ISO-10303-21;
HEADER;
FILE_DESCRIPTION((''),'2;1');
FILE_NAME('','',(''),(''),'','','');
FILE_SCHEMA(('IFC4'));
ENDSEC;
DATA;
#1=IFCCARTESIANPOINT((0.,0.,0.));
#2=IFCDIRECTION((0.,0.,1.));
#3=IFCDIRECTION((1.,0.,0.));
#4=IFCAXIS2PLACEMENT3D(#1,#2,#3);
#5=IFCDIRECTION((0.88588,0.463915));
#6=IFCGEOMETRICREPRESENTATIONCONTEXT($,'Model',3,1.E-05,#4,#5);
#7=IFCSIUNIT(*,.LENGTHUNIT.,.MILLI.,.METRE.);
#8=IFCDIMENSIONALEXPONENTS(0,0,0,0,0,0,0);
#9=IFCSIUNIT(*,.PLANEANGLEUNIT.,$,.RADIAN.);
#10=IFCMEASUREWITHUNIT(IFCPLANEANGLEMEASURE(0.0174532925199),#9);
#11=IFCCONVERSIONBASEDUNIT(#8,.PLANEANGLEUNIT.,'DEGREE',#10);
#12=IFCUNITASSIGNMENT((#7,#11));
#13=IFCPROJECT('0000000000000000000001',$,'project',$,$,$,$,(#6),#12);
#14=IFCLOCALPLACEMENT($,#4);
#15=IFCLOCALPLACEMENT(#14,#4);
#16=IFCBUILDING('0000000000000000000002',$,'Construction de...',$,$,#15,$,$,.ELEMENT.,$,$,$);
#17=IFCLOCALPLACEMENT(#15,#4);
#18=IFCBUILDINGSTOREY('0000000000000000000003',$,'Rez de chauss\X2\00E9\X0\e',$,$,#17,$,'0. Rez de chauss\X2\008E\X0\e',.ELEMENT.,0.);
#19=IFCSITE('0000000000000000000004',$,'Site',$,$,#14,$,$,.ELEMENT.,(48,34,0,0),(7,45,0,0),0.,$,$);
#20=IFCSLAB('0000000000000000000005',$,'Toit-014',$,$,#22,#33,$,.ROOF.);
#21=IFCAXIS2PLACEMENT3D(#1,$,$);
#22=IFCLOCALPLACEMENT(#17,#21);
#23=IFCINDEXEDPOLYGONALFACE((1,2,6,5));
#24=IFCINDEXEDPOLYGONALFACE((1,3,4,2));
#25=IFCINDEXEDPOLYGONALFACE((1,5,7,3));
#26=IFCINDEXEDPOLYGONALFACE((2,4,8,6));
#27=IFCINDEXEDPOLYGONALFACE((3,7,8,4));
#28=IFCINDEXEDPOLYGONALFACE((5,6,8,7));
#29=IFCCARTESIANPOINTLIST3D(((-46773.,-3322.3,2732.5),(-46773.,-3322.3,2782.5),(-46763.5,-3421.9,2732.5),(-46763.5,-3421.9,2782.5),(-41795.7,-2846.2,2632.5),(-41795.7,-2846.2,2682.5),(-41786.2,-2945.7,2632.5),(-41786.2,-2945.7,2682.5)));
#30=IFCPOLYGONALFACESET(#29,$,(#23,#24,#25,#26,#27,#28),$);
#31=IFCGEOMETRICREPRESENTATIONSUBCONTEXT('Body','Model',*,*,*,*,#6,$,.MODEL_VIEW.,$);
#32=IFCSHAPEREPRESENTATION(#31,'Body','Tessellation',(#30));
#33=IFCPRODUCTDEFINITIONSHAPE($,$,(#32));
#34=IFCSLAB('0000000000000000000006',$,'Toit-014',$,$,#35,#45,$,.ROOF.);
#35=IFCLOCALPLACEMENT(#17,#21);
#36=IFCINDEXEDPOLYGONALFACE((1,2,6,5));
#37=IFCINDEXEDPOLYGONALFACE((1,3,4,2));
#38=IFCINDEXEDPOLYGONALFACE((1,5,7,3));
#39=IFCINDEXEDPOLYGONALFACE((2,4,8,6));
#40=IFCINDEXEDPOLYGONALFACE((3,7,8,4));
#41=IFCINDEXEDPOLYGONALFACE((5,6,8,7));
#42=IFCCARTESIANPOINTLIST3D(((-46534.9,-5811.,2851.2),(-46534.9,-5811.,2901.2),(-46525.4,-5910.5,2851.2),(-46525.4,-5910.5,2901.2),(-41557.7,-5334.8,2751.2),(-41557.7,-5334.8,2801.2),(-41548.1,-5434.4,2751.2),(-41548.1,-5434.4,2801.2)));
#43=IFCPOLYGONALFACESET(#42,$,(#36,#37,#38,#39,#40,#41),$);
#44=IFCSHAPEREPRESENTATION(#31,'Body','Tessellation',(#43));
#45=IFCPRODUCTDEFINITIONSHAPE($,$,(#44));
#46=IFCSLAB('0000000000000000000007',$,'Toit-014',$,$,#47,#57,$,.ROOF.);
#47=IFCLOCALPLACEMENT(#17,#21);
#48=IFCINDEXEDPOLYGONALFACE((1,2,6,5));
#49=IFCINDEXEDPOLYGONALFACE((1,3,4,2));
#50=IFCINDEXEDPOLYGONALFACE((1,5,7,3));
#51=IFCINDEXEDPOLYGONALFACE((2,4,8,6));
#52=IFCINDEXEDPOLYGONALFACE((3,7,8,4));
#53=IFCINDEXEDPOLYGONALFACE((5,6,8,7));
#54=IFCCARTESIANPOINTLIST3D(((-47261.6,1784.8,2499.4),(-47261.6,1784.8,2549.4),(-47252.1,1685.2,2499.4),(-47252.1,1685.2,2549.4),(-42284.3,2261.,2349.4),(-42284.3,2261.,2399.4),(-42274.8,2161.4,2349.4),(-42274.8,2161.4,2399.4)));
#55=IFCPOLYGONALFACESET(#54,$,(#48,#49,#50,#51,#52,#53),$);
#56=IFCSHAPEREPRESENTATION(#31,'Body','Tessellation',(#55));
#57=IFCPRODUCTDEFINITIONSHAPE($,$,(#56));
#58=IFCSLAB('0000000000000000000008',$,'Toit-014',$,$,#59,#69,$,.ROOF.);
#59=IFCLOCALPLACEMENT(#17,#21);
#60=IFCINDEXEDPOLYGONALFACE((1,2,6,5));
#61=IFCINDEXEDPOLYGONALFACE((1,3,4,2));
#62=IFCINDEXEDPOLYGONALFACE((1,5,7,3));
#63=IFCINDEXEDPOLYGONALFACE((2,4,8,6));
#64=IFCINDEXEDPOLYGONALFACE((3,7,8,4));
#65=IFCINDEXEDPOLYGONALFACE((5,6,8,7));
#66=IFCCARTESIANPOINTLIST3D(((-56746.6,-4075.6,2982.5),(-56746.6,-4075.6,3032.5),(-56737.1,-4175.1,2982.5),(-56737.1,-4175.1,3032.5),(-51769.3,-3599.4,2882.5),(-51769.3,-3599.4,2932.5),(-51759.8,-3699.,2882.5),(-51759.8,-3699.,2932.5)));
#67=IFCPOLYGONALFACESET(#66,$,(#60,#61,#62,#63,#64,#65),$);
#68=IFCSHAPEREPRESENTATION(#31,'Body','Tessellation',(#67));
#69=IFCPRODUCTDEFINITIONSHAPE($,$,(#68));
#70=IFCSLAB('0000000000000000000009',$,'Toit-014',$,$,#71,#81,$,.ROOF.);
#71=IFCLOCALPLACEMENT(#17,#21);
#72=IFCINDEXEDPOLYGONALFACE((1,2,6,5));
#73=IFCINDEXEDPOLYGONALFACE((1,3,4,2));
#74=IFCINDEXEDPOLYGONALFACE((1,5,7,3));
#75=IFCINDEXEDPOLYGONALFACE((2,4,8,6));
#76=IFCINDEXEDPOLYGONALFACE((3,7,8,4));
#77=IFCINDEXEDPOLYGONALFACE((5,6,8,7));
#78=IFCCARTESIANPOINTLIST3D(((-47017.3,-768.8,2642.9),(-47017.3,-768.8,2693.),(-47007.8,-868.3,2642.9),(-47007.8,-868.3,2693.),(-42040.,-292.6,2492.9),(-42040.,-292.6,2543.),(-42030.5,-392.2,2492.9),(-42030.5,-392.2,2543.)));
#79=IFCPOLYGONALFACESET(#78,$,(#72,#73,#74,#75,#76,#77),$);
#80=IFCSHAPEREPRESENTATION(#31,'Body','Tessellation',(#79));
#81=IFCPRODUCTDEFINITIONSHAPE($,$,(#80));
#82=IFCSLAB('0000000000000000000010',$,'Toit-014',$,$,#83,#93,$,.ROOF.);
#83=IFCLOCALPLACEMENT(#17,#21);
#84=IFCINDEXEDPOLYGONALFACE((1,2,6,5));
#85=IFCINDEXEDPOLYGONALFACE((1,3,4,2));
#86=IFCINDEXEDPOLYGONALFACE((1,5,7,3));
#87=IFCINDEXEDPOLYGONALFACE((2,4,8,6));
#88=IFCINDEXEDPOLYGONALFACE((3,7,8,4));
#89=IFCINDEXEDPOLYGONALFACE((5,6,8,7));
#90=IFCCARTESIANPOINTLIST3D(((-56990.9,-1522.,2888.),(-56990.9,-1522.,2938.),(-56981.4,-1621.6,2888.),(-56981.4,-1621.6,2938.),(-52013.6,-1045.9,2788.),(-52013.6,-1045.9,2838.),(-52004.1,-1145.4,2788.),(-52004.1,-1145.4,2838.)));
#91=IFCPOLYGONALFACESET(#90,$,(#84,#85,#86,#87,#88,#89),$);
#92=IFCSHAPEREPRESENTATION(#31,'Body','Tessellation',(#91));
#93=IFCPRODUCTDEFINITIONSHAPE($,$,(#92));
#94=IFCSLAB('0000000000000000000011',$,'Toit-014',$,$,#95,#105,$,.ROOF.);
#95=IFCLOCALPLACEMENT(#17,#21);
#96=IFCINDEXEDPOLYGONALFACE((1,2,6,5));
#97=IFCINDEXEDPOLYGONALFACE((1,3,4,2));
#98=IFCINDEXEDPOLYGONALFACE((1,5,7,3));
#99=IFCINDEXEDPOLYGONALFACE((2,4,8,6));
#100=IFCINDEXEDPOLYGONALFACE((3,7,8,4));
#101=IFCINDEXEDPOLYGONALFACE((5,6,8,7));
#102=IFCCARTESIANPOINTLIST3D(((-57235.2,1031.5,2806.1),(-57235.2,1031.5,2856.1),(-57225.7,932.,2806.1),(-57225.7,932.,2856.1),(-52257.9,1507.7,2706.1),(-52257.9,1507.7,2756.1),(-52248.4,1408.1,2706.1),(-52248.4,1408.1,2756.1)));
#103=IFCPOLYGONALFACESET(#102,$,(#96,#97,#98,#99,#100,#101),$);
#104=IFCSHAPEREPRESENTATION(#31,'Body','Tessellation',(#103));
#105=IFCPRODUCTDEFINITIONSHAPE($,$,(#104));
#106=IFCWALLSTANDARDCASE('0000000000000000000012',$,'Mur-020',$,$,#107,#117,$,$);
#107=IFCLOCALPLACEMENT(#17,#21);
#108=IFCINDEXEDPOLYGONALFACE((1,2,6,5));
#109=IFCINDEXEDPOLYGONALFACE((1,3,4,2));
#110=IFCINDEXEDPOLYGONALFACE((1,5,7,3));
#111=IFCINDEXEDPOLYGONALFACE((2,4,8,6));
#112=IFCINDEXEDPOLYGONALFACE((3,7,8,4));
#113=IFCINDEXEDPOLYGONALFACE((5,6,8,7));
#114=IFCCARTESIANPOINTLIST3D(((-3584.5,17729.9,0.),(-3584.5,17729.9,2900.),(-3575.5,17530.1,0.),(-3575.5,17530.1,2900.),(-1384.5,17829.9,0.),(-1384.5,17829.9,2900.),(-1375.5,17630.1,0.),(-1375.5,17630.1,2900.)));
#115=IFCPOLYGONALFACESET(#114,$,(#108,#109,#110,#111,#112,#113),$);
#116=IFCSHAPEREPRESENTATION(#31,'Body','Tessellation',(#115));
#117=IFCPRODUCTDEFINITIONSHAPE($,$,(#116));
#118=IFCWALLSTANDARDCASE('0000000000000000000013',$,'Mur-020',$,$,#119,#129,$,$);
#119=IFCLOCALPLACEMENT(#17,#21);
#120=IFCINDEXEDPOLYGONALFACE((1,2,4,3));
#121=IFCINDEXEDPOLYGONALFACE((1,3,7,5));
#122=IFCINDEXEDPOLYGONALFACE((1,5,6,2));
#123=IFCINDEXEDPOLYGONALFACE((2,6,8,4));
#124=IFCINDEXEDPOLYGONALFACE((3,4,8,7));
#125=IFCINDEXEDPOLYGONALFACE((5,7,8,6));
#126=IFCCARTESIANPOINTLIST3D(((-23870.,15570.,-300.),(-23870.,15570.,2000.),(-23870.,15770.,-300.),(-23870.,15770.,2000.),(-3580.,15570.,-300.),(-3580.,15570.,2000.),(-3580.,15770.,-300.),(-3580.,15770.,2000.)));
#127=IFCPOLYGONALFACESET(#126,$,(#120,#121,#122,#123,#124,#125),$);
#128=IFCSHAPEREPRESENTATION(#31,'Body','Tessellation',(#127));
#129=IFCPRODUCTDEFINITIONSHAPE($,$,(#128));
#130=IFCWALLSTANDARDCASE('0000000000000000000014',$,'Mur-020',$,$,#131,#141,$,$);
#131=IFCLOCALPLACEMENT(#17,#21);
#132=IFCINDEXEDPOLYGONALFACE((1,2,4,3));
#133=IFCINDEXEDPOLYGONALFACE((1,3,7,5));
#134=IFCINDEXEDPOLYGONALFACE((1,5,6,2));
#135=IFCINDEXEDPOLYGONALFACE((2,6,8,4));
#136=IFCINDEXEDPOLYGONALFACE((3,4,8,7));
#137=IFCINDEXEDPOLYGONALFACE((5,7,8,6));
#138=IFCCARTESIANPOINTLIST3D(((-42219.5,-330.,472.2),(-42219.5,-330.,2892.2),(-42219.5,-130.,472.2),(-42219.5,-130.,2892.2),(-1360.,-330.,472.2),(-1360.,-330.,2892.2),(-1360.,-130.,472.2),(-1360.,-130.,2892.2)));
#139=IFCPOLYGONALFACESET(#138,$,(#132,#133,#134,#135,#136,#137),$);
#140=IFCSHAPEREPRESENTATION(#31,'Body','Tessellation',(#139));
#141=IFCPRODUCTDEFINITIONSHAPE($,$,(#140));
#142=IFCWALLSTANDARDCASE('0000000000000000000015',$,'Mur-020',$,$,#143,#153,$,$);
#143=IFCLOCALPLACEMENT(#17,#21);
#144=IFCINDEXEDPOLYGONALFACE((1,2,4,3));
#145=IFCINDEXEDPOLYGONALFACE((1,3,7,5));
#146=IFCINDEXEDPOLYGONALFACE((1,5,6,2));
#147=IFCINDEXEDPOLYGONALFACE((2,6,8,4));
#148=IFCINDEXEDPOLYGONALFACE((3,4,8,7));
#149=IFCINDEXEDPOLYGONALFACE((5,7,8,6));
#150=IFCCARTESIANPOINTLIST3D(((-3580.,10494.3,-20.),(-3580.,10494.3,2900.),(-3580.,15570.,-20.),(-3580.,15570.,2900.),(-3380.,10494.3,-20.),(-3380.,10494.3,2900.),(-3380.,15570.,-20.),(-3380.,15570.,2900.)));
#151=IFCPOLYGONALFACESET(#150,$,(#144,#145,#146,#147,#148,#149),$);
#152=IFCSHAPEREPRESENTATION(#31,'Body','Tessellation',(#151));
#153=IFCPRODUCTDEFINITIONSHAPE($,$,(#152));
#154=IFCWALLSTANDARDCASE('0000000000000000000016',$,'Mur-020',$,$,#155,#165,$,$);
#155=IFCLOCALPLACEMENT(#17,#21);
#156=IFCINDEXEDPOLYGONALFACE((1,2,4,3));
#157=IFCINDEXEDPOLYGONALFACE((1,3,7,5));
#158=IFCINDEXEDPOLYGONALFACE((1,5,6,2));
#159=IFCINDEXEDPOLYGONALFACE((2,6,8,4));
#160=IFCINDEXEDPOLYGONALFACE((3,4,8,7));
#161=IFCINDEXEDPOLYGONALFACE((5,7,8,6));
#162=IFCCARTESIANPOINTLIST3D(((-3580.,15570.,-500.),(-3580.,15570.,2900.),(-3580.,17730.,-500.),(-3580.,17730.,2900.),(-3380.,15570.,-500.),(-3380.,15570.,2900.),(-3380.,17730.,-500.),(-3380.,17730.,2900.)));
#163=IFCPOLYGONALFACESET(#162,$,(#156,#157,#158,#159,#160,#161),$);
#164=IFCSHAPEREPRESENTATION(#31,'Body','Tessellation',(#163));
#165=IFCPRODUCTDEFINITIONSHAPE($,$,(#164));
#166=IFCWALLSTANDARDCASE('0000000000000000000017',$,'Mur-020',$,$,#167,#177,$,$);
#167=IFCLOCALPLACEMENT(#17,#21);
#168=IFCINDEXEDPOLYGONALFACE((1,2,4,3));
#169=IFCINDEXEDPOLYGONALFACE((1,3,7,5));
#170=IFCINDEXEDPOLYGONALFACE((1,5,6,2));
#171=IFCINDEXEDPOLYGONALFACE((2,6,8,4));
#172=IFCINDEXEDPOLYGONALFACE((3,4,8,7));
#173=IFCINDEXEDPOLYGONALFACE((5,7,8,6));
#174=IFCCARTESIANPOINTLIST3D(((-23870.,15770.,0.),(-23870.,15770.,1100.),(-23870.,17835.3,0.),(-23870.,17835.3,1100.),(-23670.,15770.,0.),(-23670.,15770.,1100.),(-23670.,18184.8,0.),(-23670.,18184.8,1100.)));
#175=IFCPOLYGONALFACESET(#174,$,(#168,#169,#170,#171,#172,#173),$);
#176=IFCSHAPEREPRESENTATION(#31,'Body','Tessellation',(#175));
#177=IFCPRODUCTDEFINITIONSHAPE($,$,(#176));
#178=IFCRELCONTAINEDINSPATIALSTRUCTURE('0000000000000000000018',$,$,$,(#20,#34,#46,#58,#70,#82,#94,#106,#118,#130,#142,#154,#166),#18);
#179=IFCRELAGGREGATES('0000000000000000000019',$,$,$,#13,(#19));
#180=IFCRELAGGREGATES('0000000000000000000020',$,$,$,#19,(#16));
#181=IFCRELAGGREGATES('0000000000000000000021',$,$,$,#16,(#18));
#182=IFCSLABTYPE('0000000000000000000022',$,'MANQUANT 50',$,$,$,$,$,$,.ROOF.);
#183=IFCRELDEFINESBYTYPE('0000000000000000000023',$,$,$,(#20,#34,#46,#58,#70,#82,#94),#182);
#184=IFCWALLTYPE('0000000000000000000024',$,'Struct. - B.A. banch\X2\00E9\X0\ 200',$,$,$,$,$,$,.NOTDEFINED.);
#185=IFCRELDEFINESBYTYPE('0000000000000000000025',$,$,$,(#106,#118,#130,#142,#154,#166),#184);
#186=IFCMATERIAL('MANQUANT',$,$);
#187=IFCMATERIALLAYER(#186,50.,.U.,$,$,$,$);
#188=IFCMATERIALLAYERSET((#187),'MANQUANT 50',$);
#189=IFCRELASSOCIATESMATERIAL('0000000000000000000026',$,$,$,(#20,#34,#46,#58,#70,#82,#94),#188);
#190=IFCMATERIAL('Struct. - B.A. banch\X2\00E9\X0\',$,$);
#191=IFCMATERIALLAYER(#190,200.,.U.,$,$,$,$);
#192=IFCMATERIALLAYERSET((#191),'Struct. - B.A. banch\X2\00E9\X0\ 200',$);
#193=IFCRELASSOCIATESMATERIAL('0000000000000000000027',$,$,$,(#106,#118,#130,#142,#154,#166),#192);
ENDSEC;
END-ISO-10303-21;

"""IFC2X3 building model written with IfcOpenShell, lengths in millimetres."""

from ifc_helpers import new_model, entity, si_unit, converted_unit, direction, frame, origin_with_axes, place, context, subcontext, project, spatial, polyline, outline, extrude, material, layer, layer_set, layer_usage, type_object, element, save


model = new_model("IFC2X3")

# Units and contexts
model_context = context("Model", 3, precision=1e-05, world=origin_with_axes(), true_north=direction((0.88588, 0.463915)))
body_context = subcontext(model_context, "Body", "Model", "MODEL_VIEW")
ifc_project = project(units=[si_unit("LENGTHUNIT", "METRE", prefix="MILLI"), converted_unit("PLANEANGLEUNIT", "DEGREE", entity("IfcPlaneAngleMeasure", 0.0174532925199), si_unit("PLANEANGLEUNIT", "RADIAN"), dimensions=[0, 0, 0, 0, 0, 0, 0])], contexts=[model_context])

# Site, building, storey
site_placement = place(None, origin_with_axes())
site = spatial("IfcSite", under=ifc_project, at=site_placement, Name="Site", CompositionType="ELEMENT", RefLatitude=(48, 34, 0, 0), RefLongitude=(7, 45, 0, 0), RefElevation=0.0)
building_placement = place(site_placement, origin_with_axes())
building = spatial("IfcBuilding", under=site, at=building_placement, Name="Construction de...", CompositionType="ELEMENT")
storey_placement = place(building_placement, origin_with_axes())
storey = spatial("IfcBuildingStorey", under=building, at=storey_placement, Name="Rez de chaussée", LongName="0. Rez de chauss\u008ee", CompositionType="ELEMENT", Elevation=0.0)

# Slabs
ifc_material_1 = material(Name="MANQUANT")
ifc_layer_1 = layer(ifc_material_1, 50.0, ventilated="UNKNOWN")
ifc_layer_set_1 = layer_set([ifc_layer_1], Name="MANQUANT 50")
ifc_layer_usage_1 = layer_usage(ifc_layer_set_1, "AXIS3", "NEGATIVE", 50.0)
slab_type_1 = type_object("IfcSlabType", Name="MANQUANT 50", PredefinedType="ROOF")
slab_1_placement = place(storey_placement, frame((-41786.2, -2945.7, 2632.5), z_axis=(0.0, 0.0, 1.0), x_axis=(-0.095235, 0.995455, 0.0)))
element("IfcSlab", 1, at=slab_1_placement, inside=storey, type_object=slab_type_1, material=ifc_layer_usage_1, Name="Toit-014", PredefinedType="ROOF", context=body_context, shape_type="SweptSolid", body=[
    extrude(outline(polyline([(0.0, 0.0), (100.0, 0.0), (100.0, 5001.0), (0.0, 5001.0), (0.0, 0.0)])), frame((0.0, 0.0, 0.0), z_axis=(0.0, -0.019996, 0.9998), x_axis=(1.0, 0.0, 0.0)), (0.0, 0.019996, 0.9998), 50.0),
])
ifc_layer_usage_2 = layer_usage(ifc_layer_set_1, "AXIS3", "NEGATIVE", 50.0)
slab_2_placement = place(storey_placement, frame((-41548.1, -5434.4, 2751.2), z_axis=(0.0, 0.0, 1.0), x_axis=(-0.095235, 0.995455, 0.0)))
element("IfcSlab", 2, at=slab_2_placement, inside=storey, type_object=slab_type_1, material=ifc_layer_usage_2, Name="Toit-014", PredefinedType="ROOF", context=body_context, shape_type="SweptSolid", body=[
    extrude(outline(polyline([(0.0, 0.0), (100.0, 0.0), (100.0, 5001.0), (0.0, 5001.0), (0.0, 0.0)])), frame((0.0, 0.0, 0.0), z_axis=(0.0, -0.019996, 0.9998), x_axis=(1.0, 0.0, 0.0)), (0.0, 0.019996, 0.9998), 50.0),
])
ifc_layer_usage_3 = layer_usage(ifc_layer_set_1, "AXIS3", "NEGATIVE", 50.0)
slab_3_placement = place(storey_placement, frame((-42274.8, 2161.4, 2349.4), z_axis=(0.0, 0.0, 1.0), x_axis=(-0.095235, 0.995455, 0.0)))
element("IfcSlab", 3, at=slab_3_placement, inside=storey, type_object=slab_type_1, material=ifc_layer_usage_3, Name="Toit-014", PredefinedType="ROOF", context=body_context, shape_type="SweptSolid", body=[
    extrude(outline(polyline([(0.0, 0.0), (100.0, 0.0), (100.0, 5002.2), (0.0, 5002.2), (0.0, 0.0)])), frame((0.0, 0.0, 0.0), z_axis=(0.0, -0.029987, 0.99955), x_axis=(1.0, 0.0, 0.0)), (0.0, 0.029987, 0.99955), 50.0),
])
ifc_layer_usage_4 = layer_usage(ifc_layer_set_1, "AXIS3", "NEGATIVE", 50.0)
slab_4_placement = place(storey_placement, frame((-51759.8, -3699.0, 2882.5), z_axis=(0.0, 0.0, 1.0), x_axis=(-0.095235, 0.995455, 0.0)))
element("IfcSlab", 4, at=slab_4_placement, inside=storey, type_object=slab_type_1, material=ifc_layer_usage_4, Name="Toit-014", PredefinedType="ROOF", context=body_context, shape_type="SweptSolid", body=[
    extrude(outline(polyline([(0.0, 0.0), (100.0, 0.0), (100.0, 5001.0), (0.0, 5001.0), (0.0, 0.0)])), frame((0.0, 0.0, 0.0), z_axis=(0.0, -0.019996, 0.9998), x_axis=(1.0, 0.0, 0.0)), (0.0, 0.019996, 0.9998), 50.0),
])
ifc_layer_usage_5 = layer_usage(ifc_layer_set_1, "AXIS3", "NEGATIVE", 50.0)
slab_5_placement = place(storey_placement, frame((-42030.5, -392.2, 2492.9), z_axis=(0.0, 0.0, 1.0), x_axis=(-0.095235, 0.995455, 0.0)))
element("IfcSlab", 5, at=slab_5_placement, inside=storey, type_object=slab_type_1, material=ifc_layer_usage_5, Name="Toit-014", PredefinedType="ROOF", context=body_context, shape_type="SweptSolid", body=[
    extrude(outline(polyline([(0.0, 0.0), (100.0, 0.0), (100.0, 5002.2), (0.0, 5002.2), (0.0, 0.0)])), frame((0.0, 0.0, 0.0), z_axis=(0.0, -0.029987, 0.99955), x_axis=(1.0, 0.0, 0.0)), (0.0, 0.029987, 0.99955), 50.0),
])
ifc_layer_usage_6 = layer_usage(ifc_layer_set_1, "AXIS3", "NEGATIVE", 50.0)
slab_6_placement = place(storey_placement, frame((-52004.1, -1145.4, 2788.0), z_axis=(0.0, 0.0, 1.0), x_axis=(-0.095235, 0.995455, 0.0)))
element("IfcSlab", 6, at=slab_6_placement, inside=storey, type_object=slab_type_1, material=ifc_layer_usage_6, Name="Toit-014", PredefinedType="ROOF", context=body_context, shape_type="SweptSolid", body=[
    extrude(outline(polyline([(0.0, 0.0), (100.0, 0.0), (100.0, 5001.0), (0.0, 5001.0), (0.0, 0.0)])), frame((0.0, 0.0, 0.0), z_axis=(0.0, -0.019996, 0.9998), x_axis=(1.0, 0.0, 0.0)), (0.0, 0.019996, 0.9998), 50.0),
])
ifc_layer_usage_7 = layer_usage(ifc_layer_set_1, "AXIS3", "NEGATIVE", 50.0)
slab_7_placement = place(storey_placement, frame((-52248.4, 1408.1, 2706.1), z_axis=(0.0, 0.0, 1.0), x_axis=(-0.095235, 0.995455, 0.0)))
element("IfcSlab", 7, at=slab_7_placement, inside=storey, type_object=slab_type_1, material=ifc_layer_usage_7, Name="Toit-014", PredefinedType="ROOF", context=body_context, shape_type="SweptSolid", body=[
    extrude(outline(polyline([(0.0, 0.0), (100.0, 0.0), (100.0, 5001.0), (0.0, 5001.0), (0.0, 0.0)])), frame((0.0, 0.0, 0.0), z_axis=(0.0, -0.019996, 0.9998), x_axis=(1.0, 0.0, 0.0)), (0.0, 0.019996, 0.9998), 50.0),
])

# Walls
ifc_material_2 = material(Name="Struct. - B.A. banché")
ifc_layer_2 = layer(ifc_material_2, 200.0, ventilated="UNKNOWN")
ifc_layer_set_2 = layer_set([ifc_layer_2], Name="Struct. - B.A. banché 200")
ifc_layer_usage_8 = layer_usage(ifc_layer_set_2, "AXIS2", "NEGATIVE", 100.0)
wall_type_1 = type_object("IfcWallType", Name="Struct. - B.A. banché 200", PredefinedType="NOTDEFINED")
wall_1_placement = place(storey_placement, frame((-3580.0, 17630.0, 0.0), z_axis=(0.0, 0.0, 1.0), x_axis=(0.998969, 0.045408, 0.0)))
element("IfcWallStandardCase", 8, at=wall_1_placement, inside=storey, type_object=wall_type_1, material=ifc_layer_usage_8, Name="Mur-020", context=body_context, shape_type="SweptSolid", body=[
    extrude(outline(polyline([(0.0, -100.0), (2202.3, -100.0), (2202.3, 100.0), (0.0, 100.0), (0.0, -100.0)])), origin_with_axes(), (0.0, 0.0, 1.0), 2900.0),
])
ifc_layer_usage_9 = layer_usage(ifc_layer_set_2, "AXIS2", "NEGATIVE", 100.0)
wall_2_placement = place(storey_placement, frame((-23870.0, 15670.0, -300.0), z_axis=(0.0, 0.0, 1.0), x_axis=(1.0, 0.0, 0.0)))
element("IfcWallStandardCase", 9, at=wall_2_placement, inside=storey, type_object=wall_type_1, material=ifc_layer_usage_9, Name="Mur-020", context=body_context, shape_type="SweptSolid", body=[
    extrude(outline(polyline([(0.0, -100.0), (20290.0, -100.0), (20290.0, 100.0), (0.0, 100.0), (0.0, -100.0)])), origin_with_axes(), (0.0, 0.0, 1.0), 2300.0),
])
ifc_layer_usage_10 = layer_usage(ifc_layer_set_2, "AXIS2", "NEGATIVE", 100.0)
wall_3_placement = place(storey_placement, frame((-42219.5, -230.0, 472.2), z_axis=(0.0, 0.0, 1.0), x_axis=(1.0, 0.0, 0.0)))
element("IfcWallStandardCase", 10, at=wall_3_placement, inside=storey, type_object=wall_type_1, material=ifc_layer_usage_10, Name="Mur-020", context=body_context, shape_type="SweptSolid", body=[
    extrude(outline(polyline([(0.0, -100.0), (40859.5, -100.0), (40859.5, 100.0), (0.0, 100.0), (0.0, -100.0)])), origin_with_axes(), (0.0, 0.0, 1.0), 2420.0),
])
ifc_layer_usage_11 = layer_usage(ifc_layer_set_2, "AXIS2", "NEGATIVE", 100.0)
wall_4_placement = place(storey_placement, frame((-3480.0, 15570.0, -20.0), z_axis=(0.0, 0.0, 1.0), x_axis=(0.0, -1.0, 0.0)))
element("IfcWallStandardCase", 11, at=wall_4_placement, inside=storey, type_object=wall_type_1, material=ifc_layer_usage_11, Name="Mur-020", context=body_context, shape_type="SweptSolid", body=[
    extrude(outline(polyline([(0.0, -100.0), (5075.7, -100.0), (5075.7, 100.0), (0.0, 100.0), (0.0, -100.0)])), origin_with_axes(), (0.0, 0.0, 1.0), 2920.0),
])
ifc_layer_usage_12 = layer_usage(ifc_layer_set_2, "AXIS2", "NEGATIVE", 100.0)
wall_5_placement = place(storey_placement, frame((-3480.0, 17730.0, -500.0), z_axis=(0.0, 0.0, 1.0), x_axis=(0.0, -1.0, 0.0)))
element("IfcWallStandardCase", 12, at=wall_5_placement, inside=storey, type_object=wall_type_1, material=ifc_layer_usage_12, Name="Mur-020", context=body_context, shape_type="SweptSolid", body=[
    extrude(outline(polyline([(0.0, -100.0), (2160.0, -100.0), (2160.0, 100.0), (0.0, 100.0), (0.0, -100.0)])), origin_with_axes(), (0.0, 0.0, 1.0), 3400.0),
])
ifc_layer_usage_13 = layer_usage(ifc_layer_set_2, "AXIS2", "NEGATIVE", 100.0)
wall_6_placement = place(storey_placement, frame((-23770.0, 18010.0, 0.0), z_axis=(0.0, 0.0, 1.0), x_axis=(0.0, -1.0, 0.0)))
element("IfcWallStandardCase", 13, at=wall_6_placement, inside=storey, type_object=wall_type_1, material=ifc_layer_usage_13, Name="Mur-020", context=body_context, shape_type="SweptSolid", body=[
    extrude(outline(polyline([(174.8, -100.0), (2240.0, -100.0), (2240.0, 100.0), (-174.8, 100.0), (174.8, -100.0)])), origin_with_axes(), (0.0, 0.0, 1.0), 1100.0),
])

save(model, "model.ifc")
